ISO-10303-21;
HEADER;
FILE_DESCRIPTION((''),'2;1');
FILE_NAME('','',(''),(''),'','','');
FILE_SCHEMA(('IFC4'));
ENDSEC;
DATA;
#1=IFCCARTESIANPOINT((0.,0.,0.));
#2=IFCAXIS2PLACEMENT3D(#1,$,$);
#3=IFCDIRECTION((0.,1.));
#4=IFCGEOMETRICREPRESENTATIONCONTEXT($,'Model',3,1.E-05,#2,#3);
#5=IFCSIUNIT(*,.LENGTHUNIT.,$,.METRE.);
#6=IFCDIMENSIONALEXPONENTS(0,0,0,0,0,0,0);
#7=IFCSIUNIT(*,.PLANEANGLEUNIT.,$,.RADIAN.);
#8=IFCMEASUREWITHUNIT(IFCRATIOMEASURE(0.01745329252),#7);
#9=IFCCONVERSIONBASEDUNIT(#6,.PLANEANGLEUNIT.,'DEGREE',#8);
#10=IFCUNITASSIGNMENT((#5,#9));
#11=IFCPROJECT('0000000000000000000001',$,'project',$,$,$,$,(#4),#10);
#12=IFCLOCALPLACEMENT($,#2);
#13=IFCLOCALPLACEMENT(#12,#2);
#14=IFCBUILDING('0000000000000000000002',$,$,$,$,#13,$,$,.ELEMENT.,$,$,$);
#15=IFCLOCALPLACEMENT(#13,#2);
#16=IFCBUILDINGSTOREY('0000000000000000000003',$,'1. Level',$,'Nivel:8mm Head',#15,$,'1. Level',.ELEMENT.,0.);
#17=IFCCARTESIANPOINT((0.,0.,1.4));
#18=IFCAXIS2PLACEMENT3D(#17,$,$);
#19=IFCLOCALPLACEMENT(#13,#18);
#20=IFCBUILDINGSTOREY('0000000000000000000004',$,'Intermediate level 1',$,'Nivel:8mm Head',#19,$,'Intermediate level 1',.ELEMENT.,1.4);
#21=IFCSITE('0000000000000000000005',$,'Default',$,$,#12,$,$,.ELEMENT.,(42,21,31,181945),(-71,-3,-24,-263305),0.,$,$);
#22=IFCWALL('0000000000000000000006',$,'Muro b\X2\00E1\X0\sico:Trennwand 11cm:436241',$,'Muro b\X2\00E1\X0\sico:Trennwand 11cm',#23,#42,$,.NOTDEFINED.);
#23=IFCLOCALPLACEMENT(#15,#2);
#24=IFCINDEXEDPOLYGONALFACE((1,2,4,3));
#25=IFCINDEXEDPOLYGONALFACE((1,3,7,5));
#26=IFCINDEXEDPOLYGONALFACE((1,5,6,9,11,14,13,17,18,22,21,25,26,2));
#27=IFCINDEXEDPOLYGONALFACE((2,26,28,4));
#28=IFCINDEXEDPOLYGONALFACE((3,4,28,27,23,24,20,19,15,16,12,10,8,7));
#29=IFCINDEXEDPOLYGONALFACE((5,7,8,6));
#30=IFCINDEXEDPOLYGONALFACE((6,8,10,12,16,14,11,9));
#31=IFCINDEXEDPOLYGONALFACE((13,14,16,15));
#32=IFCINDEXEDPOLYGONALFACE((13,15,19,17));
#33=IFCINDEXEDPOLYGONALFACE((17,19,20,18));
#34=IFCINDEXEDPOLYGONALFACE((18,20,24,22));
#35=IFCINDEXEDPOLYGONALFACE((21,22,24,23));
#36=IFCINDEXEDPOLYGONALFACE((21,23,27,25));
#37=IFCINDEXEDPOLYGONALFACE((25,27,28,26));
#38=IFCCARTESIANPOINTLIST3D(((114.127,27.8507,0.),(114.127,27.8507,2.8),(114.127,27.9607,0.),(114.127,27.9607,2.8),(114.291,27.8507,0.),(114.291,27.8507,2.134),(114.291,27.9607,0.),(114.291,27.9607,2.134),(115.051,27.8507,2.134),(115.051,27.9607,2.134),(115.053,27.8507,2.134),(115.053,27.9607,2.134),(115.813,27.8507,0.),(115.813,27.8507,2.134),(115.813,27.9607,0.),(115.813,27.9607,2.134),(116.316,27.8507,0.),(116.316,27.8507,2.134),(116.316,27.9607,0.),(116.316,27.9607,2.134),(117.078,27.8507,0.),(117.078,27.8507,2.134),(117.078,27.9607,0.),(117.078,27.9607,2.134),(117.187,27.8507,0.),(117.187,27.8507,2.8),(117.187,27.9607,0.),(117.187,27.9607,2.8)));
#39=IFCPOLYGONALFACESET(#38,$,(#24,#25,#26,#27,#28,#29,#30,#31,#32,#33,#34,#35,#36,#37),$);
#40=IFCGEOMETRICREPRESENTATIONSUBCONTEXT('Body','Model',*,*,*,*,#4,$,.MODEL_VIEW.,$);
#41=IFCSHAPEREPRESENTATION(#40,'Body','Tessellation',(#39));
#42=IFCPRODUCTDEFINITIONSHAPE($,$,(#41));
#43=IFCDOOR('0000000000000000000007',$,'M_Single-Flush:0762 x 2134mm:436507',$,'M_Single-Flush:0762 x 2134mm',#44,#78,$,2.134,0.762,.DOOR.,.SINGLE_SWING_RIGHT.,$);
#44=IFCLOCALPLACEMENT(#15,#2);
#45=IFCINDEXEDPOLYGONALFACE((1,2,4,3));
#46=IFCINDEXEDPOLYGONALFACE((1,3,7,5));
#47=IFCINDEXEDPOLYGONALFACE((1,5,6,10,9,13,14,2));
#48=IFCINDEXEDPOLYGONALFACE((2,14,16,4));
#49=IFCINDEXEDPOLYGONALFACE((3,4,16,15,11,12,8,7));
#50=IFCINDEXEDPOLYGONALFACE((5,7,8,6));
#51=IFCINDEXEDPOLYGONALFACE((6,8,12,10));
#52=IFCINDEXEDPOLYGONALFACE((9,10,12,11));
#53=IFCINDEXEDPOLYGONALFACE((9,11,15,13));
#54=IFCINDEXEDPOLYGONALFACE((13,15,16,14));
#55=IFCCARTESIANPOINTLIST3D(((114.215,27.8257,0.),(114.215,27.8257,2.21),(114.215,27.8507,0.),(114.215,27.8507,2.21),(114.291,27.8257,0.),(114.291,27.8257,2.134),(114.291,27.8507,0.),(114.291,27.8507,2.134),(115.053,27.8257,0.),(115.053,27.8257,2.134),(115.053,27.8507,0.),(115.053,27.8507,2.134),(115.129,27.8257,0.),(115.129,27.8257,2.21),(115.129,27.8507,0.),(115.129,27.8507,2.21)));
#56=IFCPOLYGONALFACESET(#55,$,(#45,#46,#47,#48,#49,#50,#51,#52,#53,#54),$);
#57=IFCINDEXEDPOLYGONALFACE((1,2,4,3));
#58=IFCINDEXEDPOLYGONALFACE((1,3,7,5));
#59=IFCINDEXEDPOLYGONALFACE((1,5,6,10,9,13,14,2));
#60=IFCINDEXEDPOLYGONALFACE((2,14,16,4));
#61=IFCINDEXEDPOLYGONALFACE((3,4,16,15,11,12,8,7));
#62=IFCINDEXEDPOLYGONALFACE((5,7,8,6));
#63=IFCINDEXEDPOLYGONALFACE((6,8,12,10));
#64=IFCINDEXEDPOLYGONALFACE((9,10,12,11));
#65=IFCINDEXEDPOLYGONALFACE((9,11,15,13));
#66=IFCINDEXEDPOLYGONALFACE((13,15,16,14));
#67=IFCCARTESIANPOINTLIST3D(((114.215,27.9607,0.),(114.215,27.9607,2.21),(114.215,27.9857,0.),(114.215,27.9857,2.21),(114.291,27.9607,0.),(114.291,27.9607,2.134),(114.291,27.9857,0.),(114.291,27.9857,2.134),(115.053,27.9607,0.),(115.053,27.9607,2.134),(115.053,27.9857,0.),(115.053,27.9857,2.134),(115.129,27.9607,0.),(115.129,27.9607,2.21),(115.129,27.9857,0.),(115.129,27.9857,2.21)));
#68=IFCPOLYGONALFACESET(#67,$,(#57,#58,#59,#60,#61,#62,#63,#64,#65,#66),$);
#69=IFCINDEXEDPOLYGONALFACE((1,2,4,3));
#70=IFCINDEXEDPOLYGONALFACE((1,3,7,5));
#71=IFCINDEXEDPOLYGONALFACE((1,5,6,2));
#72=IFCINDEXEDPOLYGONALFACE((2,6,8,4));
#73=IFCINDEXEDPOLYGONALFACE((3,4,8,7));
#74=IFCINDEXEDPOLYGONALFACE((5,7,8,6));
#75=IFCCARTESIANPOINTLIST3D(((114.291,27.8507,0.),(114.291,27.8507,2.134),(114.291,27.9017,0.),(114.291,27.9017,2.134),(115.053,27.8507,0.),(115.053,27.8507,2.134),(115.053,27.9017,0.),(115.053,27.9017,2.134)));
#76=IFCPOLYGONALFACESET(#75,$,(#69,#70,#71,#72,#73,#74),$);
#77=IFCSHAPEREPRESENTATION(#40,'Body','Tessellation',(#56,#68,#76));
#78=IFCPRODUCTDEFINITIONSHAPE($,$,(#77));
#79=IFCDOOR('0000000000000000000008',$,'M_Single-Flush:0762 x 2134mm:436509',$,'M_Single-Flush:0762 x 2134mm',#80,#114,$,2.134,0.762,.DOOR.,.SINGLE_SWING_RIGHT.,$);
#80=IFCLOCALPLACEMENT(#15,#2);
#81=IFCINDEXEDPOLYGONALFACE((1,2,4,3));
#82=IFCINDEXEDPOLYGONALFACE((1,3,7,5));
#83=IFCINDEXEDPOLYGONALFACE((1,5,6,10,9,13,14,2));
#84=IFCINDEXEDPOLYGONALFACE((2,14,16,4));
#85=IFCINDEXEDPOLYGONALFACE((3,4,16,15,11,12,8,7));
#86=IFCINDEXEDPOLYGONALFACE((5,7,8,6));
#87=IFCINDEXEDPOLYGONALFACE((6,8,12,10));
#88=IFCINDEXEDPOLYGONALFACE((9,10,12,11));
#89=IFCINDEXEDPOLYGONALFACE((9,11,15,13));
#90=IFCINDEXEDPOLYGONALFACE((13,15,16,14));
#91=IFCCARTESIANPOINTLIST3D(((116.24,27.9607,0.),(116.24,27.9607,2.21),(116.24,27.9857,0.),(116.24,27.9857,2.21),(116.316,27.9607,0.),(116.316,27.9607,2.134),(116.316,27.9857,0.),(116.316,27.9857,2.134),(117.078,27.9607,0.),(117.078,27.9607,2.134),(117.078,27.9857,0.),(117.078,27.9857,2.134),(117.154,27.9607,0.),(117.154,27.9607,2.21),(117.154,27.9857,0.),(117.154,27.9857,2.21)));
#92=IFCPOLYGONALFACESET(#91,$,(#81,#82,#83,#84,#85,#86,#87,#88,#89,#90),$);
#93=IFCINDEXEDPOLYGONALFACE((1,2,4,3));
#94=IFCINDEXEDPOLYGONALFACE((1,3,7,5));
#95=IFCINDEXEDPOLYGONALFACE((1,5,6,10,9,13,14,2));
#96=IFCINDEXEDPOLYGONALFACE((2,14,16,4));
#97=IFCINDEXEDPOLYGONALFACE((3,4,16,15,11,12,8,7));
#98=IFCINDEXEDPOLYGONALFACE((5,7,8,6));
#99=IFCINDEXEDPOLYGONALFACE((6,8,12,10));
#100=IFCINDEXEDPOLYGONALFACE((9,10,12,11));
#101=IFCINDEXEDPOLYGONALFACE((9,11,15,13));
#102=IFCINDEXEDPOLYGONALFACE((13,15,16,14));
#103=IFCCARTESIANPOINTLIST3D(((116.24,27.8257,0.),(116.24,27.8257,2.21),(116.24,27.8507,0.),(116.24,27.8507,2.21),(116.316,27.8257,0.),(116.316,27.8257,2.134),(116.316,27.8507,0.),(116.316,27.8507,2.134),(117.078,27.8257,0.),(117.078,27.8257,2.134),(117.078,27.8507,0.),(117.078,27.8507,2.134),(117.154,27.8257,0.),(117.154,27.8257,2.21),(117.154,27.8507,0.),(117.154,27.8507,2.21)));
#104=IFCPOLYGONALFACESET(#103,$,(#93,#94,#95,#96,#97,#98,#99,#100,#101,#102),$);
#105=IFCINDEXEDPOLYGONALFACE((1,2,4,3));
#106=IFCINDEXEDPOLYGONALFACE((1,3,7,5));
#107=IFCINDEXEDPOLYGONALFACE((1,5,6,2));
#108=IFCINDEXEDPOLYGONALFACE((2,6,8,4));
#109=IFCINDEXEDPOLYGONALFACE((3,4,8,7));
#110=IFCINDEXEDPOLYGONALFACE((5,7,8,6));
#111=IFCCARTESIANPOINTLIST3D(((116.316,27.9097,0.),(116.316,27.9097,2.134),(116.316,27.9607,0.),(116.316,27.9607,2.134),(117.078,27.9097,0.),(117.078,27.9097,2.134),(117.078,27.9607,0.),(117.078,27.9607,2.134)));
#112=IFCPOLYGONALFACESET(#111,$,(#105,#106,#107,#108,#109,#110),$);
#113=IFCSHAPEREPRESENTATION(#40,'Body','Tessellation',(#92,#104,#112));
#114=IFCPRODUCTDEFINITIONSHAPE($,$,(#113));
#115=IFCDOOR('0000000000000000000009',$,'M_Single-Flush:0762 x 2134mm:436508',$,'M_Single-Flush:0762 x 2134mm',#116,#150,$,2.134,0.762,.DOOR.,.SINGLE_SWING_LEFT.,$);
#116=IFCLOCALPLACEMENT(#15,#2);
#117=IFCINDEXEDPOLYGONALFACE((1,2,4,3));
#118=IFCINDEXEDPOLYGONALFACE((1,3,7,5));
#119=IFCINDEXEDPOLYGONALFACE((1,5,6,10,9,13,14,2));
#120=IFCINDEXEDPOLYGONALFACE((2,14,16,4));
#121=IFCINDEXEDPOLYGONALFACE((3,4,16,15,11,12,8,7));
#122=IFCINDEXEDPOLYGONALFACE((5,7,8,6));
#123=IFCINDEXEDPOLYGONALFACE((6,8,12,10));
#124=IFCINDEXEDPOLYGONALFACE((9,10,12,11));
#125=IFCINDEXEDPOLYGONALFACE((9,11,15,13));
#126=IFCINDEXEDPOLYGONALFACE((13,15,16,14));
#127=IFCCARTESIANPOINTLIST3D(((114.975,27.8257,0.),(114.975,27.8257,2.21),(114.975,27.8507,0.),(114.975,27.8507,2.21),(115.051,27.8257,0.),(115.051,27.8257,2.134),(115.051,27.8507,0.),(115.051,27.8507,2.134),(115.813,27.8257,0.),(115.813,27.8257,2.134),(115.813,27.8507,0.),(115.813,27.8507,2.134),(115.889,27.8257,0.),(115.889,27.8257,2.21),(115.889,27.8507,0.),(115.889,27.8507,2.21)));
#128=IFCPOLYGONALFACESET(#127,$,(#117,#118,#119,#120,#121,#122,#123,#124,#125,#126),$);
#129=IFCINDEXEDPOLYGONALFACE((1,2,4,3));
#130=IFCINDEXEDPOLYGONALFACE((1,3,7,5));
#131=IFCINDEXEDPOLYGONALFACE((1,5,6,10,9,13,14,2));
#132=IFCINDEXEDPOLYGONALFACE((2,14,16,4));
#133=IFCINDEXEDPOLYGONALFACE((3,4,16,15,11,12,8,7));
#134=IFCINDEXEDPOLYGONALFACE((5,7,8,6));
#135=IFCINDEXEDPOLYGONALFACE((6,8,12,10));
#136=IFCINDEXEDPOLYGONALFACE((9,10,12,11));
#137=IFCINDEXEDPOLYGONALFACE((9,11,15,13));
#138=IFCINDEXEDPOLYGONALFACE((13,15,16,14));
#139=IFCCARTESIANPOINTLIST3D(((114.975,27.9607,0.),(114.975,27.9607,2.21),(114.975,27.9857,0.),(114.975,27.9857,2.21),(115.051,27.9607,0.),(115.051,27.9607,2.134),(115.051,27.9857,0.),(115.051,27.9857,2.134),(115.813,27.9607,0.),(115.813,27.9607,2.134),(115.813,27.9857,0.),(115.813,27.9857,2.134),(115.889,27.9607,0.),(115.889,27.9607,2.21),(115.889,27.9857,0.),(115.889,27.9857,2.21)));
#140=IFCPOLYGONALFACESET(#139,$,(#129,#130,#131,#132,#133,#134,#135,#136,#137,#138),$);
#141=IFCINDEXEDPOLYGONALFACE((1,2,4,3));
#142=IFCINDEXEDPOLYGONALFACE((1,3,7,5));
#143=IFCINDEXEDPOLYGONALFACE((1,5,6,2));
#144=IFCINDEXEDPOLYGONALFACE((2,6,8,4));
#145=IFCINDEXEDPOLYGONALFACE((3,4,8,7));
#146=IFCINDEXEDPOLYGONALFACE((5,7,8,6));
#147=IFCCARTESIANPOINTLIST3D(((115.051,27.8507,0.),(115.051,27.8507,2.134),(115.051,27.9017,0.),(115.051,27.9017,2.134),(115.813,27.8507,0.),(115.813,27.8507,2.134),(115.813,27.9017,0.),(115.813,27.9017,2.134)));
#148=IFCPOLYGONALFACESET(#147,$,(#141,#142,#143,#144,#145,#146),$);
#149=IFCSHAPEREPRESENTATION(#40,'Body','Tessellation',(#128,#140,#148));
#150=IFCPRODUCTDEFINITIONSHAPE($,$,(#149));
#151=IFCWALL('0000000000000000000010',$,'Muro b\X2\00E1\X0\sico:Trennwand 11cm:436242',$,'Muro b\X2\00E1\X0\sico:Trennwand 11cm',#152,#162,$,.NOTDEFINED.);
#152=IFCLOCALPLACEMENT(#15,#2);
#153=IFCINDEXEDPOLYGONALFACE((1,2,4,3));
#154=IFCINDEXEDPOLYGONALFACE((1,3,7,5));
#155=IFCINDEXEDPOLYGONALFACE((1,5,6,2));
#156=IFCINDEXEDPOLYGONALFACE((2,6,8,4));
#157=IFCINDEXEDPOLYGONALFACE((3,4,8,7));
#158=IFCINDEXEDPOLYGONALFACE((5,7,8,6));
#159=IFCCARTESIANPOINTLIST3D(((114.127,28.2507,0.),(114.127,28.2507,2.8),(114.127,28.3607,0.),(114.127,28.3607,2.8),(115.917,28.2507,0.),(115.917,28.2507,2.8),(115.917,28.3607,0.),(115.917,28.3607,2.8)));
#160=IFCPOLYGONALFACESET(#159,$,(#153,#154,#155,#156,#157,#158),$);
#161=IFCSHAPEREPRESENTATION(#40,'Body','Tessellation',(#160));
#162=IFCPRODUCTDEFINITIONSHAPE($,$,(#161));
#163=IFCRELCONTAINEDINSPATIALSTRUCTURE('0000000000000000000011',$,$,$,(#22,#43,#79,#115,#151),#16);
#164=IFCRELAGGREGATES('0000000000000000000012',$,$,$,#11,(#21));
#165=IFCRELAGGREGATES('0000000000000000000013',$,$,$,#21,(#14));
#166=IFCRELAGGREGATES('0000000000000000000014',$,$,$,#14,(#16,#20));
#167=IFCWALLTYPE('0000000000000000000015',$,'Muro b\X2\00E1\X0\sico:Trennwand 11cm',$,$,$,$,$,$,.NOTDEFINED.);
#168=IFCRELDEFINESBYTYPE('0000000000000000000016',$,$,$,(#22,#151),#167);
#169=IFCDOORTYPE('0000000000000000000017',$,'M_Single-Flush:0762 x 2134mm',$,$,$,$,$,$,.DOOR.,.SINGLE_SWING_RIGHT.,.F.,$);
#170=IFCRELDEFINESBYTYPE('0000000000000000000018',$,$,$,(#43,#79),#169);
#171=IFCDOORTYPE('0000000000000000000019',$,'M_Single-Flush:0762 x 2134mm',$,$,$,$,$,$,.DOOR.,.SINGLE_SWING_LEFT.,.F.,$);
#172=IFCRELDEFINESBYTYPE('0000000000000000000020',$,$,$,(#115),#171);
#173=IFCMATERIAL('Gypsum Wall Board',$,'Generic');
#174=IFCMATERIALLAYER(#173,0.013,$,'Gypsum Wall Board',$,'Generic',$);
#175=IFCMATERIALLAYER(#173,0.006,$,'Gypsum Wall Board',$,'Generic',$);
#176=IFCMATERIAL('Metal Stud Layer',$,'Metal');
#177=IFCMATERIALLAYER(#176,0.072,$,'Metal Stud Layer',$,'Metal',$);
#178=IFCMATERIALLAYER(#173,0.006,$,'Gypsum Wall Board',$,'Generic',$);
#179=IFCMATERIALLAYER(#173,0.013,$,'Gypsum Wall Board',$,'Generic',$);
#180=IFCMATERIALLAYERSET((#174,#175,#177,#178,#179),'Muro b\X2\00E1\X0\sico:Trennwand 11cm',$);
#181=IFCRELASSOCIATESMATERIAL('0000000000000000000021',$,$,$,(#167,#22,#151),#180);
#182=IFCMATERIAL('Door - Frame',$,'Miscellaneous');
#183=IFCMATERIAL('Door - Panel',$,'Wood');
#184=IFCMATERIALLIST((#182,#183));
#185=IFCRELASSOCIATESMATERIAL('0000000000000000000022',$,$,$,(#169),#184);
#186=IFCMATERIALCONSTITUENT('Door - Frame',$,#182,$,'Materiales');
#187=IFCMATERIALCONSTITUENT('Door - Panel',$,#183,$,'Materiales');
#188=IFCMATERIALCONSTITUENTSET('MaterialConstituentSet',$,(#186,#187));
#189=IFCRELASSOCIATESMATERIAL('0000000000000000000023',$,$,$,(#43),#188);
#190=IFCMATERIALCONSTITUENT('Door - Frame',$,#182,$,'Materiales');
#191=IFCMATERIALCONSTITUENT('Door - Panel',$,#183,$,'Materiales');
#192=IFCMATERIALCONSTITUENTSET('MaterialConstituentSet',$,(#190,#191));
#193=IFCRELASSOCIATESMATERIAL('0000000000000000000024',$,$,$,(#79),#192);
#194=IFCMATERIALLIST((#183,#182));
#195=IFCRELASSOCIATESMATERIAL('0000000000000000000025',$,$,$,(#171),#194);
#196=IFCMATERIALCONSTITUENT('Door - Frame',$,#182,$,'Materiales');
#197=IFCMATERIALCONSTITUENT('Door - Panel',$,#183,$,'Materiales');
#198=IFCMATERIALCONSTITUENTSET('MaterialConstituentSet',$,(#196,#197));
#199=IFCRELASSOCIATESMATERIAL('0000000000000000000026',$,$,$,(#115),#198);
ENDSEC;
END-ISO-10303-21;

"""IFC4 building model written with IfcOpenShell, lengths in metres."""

from ifc_helpers import new_model, entity, si_unit, converted_unit, direction, frame, frame_2d, origin, origin_2d_with_axis, place, context, subcontext, project, spatial, polyline, rectangle, outline, extrude, source, transform, mapped, material, material_list, layer, layer_set, layer_usage, constituent, constituent_set, type_object, type_shapes, element, fill, save


model = new_model("IFC4")

# Units and contexts
model_context = context("Model", 3, precision=1e-05, world=origin(), true_north=direction((0.0, 1.0)))
body_context = subcontext(model_context, "Body", "Model", "MODEL_VIEW")
ifc_project = project(units=[si_unit("LENGTHUNIT", "METRE"), converted_unit("PLANEANGLEUNIT", "DEGREE", entity("IfcRatioMeasure", 0.01745329252), si_unit("PLANEANGLEUNIT", "RADIAN"), dimensions=[0, 0, 0, 0, 0, 0, 0])], contexts=[model_context])

# Site, building, storey
site_placement = place(None, origin())
site = spatial("IfcSite", under=ifc_project, at=site_placement, Name="Default", CompositionType="ELEMENT", RefLatitude=(42, 21, 31, 181945), RefLongitude=(-71, -3, -24, -263305), RefElevation=0.0)
building_placement = place(site_placement, origin())
building = spatial("IfcBuilding", under=site, at=building_placement, CompositionType="ELEMENT")
storey_1_placement = place(building_placement, origin())
storey_1 = spatial("IfcBuildingStorey", under=building, at=storey_1_placement, Name="1. Level", ObjectType="Nivel:8mm Head", LongName="1. Level", CompositionType="ELEMENT", Elevation=0.0)

# Shared definitions
storey_2_placement = place(building_placement, frame((0.0, 0.0, 1.4)))
storey_2 = spatial("IfcBuildingStorey", under=building, at=storey_2_placement, Name="Intermediate level 1", ObjectType="Nivel:8mm Head", LongName="Intermediate level 1", CompositionType="ELEMENT", Elevation=1.4)

# Shared definitions
ifc_material_1 = material(Name="Gypsum Wall Board", Category="Generic")
ifc_layer_1 = layer(ifc_material_1, 0.013, Name="Gypsum Wall Board", Category="Generic")
ifc_layer_2 = layer(ifc_material_1, 0.006, Name="Gypsum Wall Board", Category="Generic")
ifc_material_2 = material(Name="Metal Stud Layer", Category="Metal")
ifc_layer_3 = layer(ifc_material_2, 0.072, Name="Metal Stud Layer", Category="Metal")
ifc_layer_4 = layer(ifc_material_1, 0.006, Name="Gypsum Wall Board", Category="Generic")
ifc_layer_5 = layer(ifc_material_1, 0.013, Name="Gypsum Wall Board", Category="Generic")
ifc_layer_set_1 = layer_set([ifc_layer_1, ifc_layer_2, ifc_layer_3, ifc_layer_4, ifc_layer_5], Name="Muro básico:Trennwand 11cm")
wall_type_1 = type_object("IfcWallType", Name="Muro básico:Trennwand 11cm", PredefinedType="NOTDEFINED", material=ifc_layer_set_1)
ifc_material_3 = material(Name="Door - Frame", Category="Miscellaneous")
ifc_material_4 = material(Name="Door - Panel", Category="Wood")
ifc_material_list_1 = material_list([ifc_material_3, ifc_material_4])
door_type_1 = type_object("IfcDoorType", Name="M_Single-Flush:0762 x 2134mm", OperationType="SINGLE_SWING_RIGHT", ParameterTakesPrecedence=False, PredefinedType="DOOR", material=ifc_material_list_1)
shared_shape_1 = source(origin(), body_context, "Body", "SweptSolid", [
    extrude(outline(polyline([(-0.457, -1.124), (0.457, -1.124), (0.457, 1.086), (0.381, 1.086), (0.381, -1.048), (-0.381, -1.048), (-0.381, 1.086), (-0.457, 1.086), (-0.457, -1.124)])), frame((0.381, 0.11, 1.086), z_axis=(0.0, 1.0, 0.0), x_axis=(1.0, 0.0, 0.0)), (0.0, 0.0, 1.0), 0.025),
    extrude(outline(polyline([(-1.124, -0.457), (1.086, -0.457), (1.086, -0.381), (-1.048, -0.381), (-1.048, 0.381), (1.086, 0.381), (1.086, 0.457), (-1.124, 0.457), (-1.124, -0.457)])), frame((0.381, -0.025, 1.086), z_axis=(0.0, 1.0, 0.0), x_axis=(0.0, 0.0, -1.0)), (0.0, 0.0, 1.0), 0.025),
    extrude(rectangle(XDim=0.051, YDim=0.762, at=origin_2d_with_axis()), frame((0.381, 0.0845, 0.0), z_axis=(0.0, 0.0, 1.0), x_axis=(0.0, 1.0, 0.0)), (0.0, 0.0, 1.0), 2.134),
])
type_shapes(door_type_1, [shared_shape_1])

# Wall, openings, doors
ifc_layer_usage_1 = layer_usage(ifc_layer_set_1, "AXIS2", "NEGATIVE", 0.055)
wall_1_placement = place(storey_1_placement, frame((114.127, 27.9057, 0.0)))
wall_1 = element("IfcWall", 1, at=wall_1_placement, inside=storey_1, type_object=wall_type_1, material=ifc_layer_usage_1, Name="Muro básico:Trennwand 11cm:436241", ObjectType="Muro básico:Trennwand 11cm", PredefinedType="NOTDEFINED", context=body_context, shape_type="SweptSolid", body=[
    extrude(rectangle(XDim=3.06, YDim=0.11, at=frame_2d((1.53, 0.0), x_axis=(-1.0, 0.0))), origin(), (0.0, 0.0, 1.0), 2.8),
])
opening_1_placement = place(wall_1_placement, frame((0.926, 0.055, 0.0)))
opening_1 = element("IfcOpeningElement", 2, at=opening_1_placement, cuts=wall_1, ObjectType="Opening", PredefinedType="OPENING", context=body_context, shape_type="SweptSolid", body=[
    extrude(rectangle(XDim=0.762, YDim=2.134, at=frame_2d((1.067, 0.381), x_axis=(0.0, 1.0))), frame((0.0, 0.0, 0.0), z_axis=(0.0, -1.0, 0.0), x_axis=(0.0, 0.0, 1.0)), (0.0, 0.0, 1.0), 0.11),
])
opening_2_placement = place(wall_1_placement, frame((1.686, 0.055, 0.0)))
opening_2 = element("IfcOpeningElement", 3, at=opening_2_placement, cuts=wall_1, ObjectType="Opening", PredefinedType="OPENING", context=body_context, shape_type="SweptSolid", body=[
    extrude(rectangle(XDim=0.762, YDim=2.134, at=frame_2d((1.067, 0.381), x_axis=(0.0, -1.0))), frame((0.0, 0.0, 0.0), z_axis=(0.0, -1.0, 0.0), x_axis=(0.0, 0.0, 1.0)), (0.0, 0.0, 1.0), 0.11),
])
opening_3_placement = place(wall_1_placement, frame((2.189, -0.055, 0.0)))
opening_3 = element("IfcOpeningElement", 4, at=opening_3_placement, cuts=wall_1, ObjectType="Opening", PredefinedType="OPENING", context=body_context, shape_type="SweptSolid", body=[
    extrude(rectangle(XDim=0.762, YDim=2.134, at=frame_2d((1.067, 0.381), x_axis=(0.0, 1.0))), frame((0.0, 0.0, 0.0), z_axis=(0.0, 1.0, 0.0), x_axis=(0.0, 0.0, 1.0)), (0.0, 0.0, 1.0), 0.11),
])
ifc_constituent_1 = constituent(ifc_material_3, Name="Door - Frame", Category="Materiales")
ifc_constituent_2 = constituent(ifc_material_4, Name="Door - Panel", Category="Materiales")
ifc_constituent_set_1 = constituent_set(constituents=[ifc_constituent_1, ifc_constituent_2], Name="MaterialConstituentSet")
door_1_placement = place(opening_1_placement, frame((0.0, 0.0, 0.0), z_axis=(0.0, 0.0, 1.0), x_axis=(-1.0, 0.0, 0.0)))
door_1 = element("IfcDoor", 5, at=door_1_placement, inside=storey_1, type_object=door_type_1, material=ifc_constituent_set_1, Name="M_Single-Flush:0762 x 2134mm:436507", ObjectType="M_Single-Flush:0762 x 2134mm", OperationType="SINGLE_SWING_RIGHT", OverallHeight=2.134, OverallWidth=0.762, PredefinedType="DOOR", context=body_context, shape_type="MappedRepresentation", body=[
    mapped(shared_shape_1, transform((0.0, 0.0, 0.0), scale=1.0)),
])
fill(opening_1, door_1)
ifc_constituent_3 = constituent(ifc_material_3, Name="Door - Frame", Category="Materiales")
ifc_constituent_4 = constituent(ifc_material_4, Name="Door - Panel", Category="Materiales")
ifc_constituent_set_2 = constituent_set(constituents=[ifc_constituent_3, ifc_constituent_4], Name="MaterialConstituentSet")
door_2_placement = place(opening_3_placement, origin())
door_2 = element("IfcDoor", 6, at=door_2_placement, inside=storey_1, type_object=door_type_1, material=ifc_constituent_set_2, Name="M_Single-Flush:0762 x 2134mm:436509", ObjectType="M_Single-Flush:0762 x 2134mm", OperationType="SINGLE_SWING_RIGHT", OverallHeight=2.134, OverallWidth=0.762, PredefinedType="DOOR", context=body_context, shape_type="MappedRepresentation", body=[
    mapped(shared_shape_1, transform((0.0, 0.0, 0.0), scale=1.0)),
])
fill(opening_3, door_2)
ifc_constituent_5 = constituent(ifc_material_3, Name="Door - Frame", Category="Materiales")
ifc_constituent_6 = constituent(ifc_material_4, Name="Door - Panel", Category="Materiales")
ifc_constituent_set_3 = constituent_set(constituents=[ifc_constituent_5, ifc_constituent_6], Name="MaterialConstituentSet")
ifc_material_list_2 = material_list([ifc_material_4, ifc_material_3])
door_type_2 = type_object("IfcDoorType", Name="M_Single-Flush:0762 x 2134mm", OperationType="SINGLE_SWING_LEFT", ParameterTakesPrecedence=False, PredefinedType="DOOR", material=ifc_material_list_2)
shared_shape_2 = source(origin(), body_context, "Body", "SweptSolid", [
    extrude(outline(polyline([(-0.457, -1.124), (0.457, -1.124), (0.457, 1.086), (0.381, 1.086), (0.381, -1.048), (-0.381, -1.048), (-0.381, 1.086), (-0.457, 1.086), (-0.457, -1.124)])), frame((0.381, 0.135, 1.086), z_axis=(0.0, -1.0, 0.0), x_axis=(-1.0, 0.0, 0.0)), (0.0, 0.0, 1.0), 0.025),
    extrude(outline(polyline([(-1.124, -0.457), (1.086, -0.457), (1.086, -0.381), (-1.048, -0.381), (-1.048, 0.381), (1.086, 0.381), (1.086, 0.457), (-1.124, 0.457), (-1.124, -0.457)])), frame((0.381, 0.0, 1.086), z_axis=(0.0, -1.0, 0.0), x_axis=(0.0, 0.0, -1.0)), (0.0, 0.0, 1.0), 0.025),
    extrude(rectangle(XDim=0.762, YDim=0.051, at=origin_2d_with_axis()), frame((0.381, 0.0845, 0.0)), (0.0, 0.0, 1.0), 2.134),
])
type_shapes(door_type_2, [shared_shape_2])
door_3_placement = place(opening_2_placement, frame((0.0, 0.0, 0.0), z_axis=(0.0, 0.0, 1.0), x_axis=(-1.0, 0.0, 0.0)))
door_3 = element("IfcDoor", 7, at=door_3_placement, inside=storey_1, type_object=door_type_2, material=ifc_constituent_set_3, Name="M_Single-Flush:0762 x 2134mm:436508", ObjectType="M_Single-Flush:0762 x 2134mm", OperationType="SINGLE_SWING_LEFT", OverallHeight=2.134, OverallWidth=0.762, PredefinedType="DOOR", context=body_context, shape_type="MappedRepresentation", body=[
    mapped(shared_shape_2, transform((0.0, 0.0, 0.0), scale=1.0)),
])
fill(opening_2, door_3)

# Wall
ifc_layer_usage_2 = layer_usage(ifc_layer_set_1, "AXIS2", "NEGATIVE", 0.055)
wall_2_placement = place(storey_1_placement, frame((114.127, 28.3057, 0.0)))
element("IfcWall", 8, at=wall_2_placement, inside=storey_1, type_object=wall_type_1, material=ifc_layer_usage_2, Name="Muro básico:Trennwand 11cm:436242", ObjectType="Muro básico:Trennwand 11cm", PredefinedType="NOTDEFINED", context=body_context, shape_type="SweptSolid", body=[
    extrude(rectangle(XDim=1.79, YDim=0.11, at=frame_2d((0.895, 0.0), x_axis=(-1.0, 0.0))), origin(), (0.0, 0.0, 1.0), 2.8),
])

save(model, "model.ifc")
